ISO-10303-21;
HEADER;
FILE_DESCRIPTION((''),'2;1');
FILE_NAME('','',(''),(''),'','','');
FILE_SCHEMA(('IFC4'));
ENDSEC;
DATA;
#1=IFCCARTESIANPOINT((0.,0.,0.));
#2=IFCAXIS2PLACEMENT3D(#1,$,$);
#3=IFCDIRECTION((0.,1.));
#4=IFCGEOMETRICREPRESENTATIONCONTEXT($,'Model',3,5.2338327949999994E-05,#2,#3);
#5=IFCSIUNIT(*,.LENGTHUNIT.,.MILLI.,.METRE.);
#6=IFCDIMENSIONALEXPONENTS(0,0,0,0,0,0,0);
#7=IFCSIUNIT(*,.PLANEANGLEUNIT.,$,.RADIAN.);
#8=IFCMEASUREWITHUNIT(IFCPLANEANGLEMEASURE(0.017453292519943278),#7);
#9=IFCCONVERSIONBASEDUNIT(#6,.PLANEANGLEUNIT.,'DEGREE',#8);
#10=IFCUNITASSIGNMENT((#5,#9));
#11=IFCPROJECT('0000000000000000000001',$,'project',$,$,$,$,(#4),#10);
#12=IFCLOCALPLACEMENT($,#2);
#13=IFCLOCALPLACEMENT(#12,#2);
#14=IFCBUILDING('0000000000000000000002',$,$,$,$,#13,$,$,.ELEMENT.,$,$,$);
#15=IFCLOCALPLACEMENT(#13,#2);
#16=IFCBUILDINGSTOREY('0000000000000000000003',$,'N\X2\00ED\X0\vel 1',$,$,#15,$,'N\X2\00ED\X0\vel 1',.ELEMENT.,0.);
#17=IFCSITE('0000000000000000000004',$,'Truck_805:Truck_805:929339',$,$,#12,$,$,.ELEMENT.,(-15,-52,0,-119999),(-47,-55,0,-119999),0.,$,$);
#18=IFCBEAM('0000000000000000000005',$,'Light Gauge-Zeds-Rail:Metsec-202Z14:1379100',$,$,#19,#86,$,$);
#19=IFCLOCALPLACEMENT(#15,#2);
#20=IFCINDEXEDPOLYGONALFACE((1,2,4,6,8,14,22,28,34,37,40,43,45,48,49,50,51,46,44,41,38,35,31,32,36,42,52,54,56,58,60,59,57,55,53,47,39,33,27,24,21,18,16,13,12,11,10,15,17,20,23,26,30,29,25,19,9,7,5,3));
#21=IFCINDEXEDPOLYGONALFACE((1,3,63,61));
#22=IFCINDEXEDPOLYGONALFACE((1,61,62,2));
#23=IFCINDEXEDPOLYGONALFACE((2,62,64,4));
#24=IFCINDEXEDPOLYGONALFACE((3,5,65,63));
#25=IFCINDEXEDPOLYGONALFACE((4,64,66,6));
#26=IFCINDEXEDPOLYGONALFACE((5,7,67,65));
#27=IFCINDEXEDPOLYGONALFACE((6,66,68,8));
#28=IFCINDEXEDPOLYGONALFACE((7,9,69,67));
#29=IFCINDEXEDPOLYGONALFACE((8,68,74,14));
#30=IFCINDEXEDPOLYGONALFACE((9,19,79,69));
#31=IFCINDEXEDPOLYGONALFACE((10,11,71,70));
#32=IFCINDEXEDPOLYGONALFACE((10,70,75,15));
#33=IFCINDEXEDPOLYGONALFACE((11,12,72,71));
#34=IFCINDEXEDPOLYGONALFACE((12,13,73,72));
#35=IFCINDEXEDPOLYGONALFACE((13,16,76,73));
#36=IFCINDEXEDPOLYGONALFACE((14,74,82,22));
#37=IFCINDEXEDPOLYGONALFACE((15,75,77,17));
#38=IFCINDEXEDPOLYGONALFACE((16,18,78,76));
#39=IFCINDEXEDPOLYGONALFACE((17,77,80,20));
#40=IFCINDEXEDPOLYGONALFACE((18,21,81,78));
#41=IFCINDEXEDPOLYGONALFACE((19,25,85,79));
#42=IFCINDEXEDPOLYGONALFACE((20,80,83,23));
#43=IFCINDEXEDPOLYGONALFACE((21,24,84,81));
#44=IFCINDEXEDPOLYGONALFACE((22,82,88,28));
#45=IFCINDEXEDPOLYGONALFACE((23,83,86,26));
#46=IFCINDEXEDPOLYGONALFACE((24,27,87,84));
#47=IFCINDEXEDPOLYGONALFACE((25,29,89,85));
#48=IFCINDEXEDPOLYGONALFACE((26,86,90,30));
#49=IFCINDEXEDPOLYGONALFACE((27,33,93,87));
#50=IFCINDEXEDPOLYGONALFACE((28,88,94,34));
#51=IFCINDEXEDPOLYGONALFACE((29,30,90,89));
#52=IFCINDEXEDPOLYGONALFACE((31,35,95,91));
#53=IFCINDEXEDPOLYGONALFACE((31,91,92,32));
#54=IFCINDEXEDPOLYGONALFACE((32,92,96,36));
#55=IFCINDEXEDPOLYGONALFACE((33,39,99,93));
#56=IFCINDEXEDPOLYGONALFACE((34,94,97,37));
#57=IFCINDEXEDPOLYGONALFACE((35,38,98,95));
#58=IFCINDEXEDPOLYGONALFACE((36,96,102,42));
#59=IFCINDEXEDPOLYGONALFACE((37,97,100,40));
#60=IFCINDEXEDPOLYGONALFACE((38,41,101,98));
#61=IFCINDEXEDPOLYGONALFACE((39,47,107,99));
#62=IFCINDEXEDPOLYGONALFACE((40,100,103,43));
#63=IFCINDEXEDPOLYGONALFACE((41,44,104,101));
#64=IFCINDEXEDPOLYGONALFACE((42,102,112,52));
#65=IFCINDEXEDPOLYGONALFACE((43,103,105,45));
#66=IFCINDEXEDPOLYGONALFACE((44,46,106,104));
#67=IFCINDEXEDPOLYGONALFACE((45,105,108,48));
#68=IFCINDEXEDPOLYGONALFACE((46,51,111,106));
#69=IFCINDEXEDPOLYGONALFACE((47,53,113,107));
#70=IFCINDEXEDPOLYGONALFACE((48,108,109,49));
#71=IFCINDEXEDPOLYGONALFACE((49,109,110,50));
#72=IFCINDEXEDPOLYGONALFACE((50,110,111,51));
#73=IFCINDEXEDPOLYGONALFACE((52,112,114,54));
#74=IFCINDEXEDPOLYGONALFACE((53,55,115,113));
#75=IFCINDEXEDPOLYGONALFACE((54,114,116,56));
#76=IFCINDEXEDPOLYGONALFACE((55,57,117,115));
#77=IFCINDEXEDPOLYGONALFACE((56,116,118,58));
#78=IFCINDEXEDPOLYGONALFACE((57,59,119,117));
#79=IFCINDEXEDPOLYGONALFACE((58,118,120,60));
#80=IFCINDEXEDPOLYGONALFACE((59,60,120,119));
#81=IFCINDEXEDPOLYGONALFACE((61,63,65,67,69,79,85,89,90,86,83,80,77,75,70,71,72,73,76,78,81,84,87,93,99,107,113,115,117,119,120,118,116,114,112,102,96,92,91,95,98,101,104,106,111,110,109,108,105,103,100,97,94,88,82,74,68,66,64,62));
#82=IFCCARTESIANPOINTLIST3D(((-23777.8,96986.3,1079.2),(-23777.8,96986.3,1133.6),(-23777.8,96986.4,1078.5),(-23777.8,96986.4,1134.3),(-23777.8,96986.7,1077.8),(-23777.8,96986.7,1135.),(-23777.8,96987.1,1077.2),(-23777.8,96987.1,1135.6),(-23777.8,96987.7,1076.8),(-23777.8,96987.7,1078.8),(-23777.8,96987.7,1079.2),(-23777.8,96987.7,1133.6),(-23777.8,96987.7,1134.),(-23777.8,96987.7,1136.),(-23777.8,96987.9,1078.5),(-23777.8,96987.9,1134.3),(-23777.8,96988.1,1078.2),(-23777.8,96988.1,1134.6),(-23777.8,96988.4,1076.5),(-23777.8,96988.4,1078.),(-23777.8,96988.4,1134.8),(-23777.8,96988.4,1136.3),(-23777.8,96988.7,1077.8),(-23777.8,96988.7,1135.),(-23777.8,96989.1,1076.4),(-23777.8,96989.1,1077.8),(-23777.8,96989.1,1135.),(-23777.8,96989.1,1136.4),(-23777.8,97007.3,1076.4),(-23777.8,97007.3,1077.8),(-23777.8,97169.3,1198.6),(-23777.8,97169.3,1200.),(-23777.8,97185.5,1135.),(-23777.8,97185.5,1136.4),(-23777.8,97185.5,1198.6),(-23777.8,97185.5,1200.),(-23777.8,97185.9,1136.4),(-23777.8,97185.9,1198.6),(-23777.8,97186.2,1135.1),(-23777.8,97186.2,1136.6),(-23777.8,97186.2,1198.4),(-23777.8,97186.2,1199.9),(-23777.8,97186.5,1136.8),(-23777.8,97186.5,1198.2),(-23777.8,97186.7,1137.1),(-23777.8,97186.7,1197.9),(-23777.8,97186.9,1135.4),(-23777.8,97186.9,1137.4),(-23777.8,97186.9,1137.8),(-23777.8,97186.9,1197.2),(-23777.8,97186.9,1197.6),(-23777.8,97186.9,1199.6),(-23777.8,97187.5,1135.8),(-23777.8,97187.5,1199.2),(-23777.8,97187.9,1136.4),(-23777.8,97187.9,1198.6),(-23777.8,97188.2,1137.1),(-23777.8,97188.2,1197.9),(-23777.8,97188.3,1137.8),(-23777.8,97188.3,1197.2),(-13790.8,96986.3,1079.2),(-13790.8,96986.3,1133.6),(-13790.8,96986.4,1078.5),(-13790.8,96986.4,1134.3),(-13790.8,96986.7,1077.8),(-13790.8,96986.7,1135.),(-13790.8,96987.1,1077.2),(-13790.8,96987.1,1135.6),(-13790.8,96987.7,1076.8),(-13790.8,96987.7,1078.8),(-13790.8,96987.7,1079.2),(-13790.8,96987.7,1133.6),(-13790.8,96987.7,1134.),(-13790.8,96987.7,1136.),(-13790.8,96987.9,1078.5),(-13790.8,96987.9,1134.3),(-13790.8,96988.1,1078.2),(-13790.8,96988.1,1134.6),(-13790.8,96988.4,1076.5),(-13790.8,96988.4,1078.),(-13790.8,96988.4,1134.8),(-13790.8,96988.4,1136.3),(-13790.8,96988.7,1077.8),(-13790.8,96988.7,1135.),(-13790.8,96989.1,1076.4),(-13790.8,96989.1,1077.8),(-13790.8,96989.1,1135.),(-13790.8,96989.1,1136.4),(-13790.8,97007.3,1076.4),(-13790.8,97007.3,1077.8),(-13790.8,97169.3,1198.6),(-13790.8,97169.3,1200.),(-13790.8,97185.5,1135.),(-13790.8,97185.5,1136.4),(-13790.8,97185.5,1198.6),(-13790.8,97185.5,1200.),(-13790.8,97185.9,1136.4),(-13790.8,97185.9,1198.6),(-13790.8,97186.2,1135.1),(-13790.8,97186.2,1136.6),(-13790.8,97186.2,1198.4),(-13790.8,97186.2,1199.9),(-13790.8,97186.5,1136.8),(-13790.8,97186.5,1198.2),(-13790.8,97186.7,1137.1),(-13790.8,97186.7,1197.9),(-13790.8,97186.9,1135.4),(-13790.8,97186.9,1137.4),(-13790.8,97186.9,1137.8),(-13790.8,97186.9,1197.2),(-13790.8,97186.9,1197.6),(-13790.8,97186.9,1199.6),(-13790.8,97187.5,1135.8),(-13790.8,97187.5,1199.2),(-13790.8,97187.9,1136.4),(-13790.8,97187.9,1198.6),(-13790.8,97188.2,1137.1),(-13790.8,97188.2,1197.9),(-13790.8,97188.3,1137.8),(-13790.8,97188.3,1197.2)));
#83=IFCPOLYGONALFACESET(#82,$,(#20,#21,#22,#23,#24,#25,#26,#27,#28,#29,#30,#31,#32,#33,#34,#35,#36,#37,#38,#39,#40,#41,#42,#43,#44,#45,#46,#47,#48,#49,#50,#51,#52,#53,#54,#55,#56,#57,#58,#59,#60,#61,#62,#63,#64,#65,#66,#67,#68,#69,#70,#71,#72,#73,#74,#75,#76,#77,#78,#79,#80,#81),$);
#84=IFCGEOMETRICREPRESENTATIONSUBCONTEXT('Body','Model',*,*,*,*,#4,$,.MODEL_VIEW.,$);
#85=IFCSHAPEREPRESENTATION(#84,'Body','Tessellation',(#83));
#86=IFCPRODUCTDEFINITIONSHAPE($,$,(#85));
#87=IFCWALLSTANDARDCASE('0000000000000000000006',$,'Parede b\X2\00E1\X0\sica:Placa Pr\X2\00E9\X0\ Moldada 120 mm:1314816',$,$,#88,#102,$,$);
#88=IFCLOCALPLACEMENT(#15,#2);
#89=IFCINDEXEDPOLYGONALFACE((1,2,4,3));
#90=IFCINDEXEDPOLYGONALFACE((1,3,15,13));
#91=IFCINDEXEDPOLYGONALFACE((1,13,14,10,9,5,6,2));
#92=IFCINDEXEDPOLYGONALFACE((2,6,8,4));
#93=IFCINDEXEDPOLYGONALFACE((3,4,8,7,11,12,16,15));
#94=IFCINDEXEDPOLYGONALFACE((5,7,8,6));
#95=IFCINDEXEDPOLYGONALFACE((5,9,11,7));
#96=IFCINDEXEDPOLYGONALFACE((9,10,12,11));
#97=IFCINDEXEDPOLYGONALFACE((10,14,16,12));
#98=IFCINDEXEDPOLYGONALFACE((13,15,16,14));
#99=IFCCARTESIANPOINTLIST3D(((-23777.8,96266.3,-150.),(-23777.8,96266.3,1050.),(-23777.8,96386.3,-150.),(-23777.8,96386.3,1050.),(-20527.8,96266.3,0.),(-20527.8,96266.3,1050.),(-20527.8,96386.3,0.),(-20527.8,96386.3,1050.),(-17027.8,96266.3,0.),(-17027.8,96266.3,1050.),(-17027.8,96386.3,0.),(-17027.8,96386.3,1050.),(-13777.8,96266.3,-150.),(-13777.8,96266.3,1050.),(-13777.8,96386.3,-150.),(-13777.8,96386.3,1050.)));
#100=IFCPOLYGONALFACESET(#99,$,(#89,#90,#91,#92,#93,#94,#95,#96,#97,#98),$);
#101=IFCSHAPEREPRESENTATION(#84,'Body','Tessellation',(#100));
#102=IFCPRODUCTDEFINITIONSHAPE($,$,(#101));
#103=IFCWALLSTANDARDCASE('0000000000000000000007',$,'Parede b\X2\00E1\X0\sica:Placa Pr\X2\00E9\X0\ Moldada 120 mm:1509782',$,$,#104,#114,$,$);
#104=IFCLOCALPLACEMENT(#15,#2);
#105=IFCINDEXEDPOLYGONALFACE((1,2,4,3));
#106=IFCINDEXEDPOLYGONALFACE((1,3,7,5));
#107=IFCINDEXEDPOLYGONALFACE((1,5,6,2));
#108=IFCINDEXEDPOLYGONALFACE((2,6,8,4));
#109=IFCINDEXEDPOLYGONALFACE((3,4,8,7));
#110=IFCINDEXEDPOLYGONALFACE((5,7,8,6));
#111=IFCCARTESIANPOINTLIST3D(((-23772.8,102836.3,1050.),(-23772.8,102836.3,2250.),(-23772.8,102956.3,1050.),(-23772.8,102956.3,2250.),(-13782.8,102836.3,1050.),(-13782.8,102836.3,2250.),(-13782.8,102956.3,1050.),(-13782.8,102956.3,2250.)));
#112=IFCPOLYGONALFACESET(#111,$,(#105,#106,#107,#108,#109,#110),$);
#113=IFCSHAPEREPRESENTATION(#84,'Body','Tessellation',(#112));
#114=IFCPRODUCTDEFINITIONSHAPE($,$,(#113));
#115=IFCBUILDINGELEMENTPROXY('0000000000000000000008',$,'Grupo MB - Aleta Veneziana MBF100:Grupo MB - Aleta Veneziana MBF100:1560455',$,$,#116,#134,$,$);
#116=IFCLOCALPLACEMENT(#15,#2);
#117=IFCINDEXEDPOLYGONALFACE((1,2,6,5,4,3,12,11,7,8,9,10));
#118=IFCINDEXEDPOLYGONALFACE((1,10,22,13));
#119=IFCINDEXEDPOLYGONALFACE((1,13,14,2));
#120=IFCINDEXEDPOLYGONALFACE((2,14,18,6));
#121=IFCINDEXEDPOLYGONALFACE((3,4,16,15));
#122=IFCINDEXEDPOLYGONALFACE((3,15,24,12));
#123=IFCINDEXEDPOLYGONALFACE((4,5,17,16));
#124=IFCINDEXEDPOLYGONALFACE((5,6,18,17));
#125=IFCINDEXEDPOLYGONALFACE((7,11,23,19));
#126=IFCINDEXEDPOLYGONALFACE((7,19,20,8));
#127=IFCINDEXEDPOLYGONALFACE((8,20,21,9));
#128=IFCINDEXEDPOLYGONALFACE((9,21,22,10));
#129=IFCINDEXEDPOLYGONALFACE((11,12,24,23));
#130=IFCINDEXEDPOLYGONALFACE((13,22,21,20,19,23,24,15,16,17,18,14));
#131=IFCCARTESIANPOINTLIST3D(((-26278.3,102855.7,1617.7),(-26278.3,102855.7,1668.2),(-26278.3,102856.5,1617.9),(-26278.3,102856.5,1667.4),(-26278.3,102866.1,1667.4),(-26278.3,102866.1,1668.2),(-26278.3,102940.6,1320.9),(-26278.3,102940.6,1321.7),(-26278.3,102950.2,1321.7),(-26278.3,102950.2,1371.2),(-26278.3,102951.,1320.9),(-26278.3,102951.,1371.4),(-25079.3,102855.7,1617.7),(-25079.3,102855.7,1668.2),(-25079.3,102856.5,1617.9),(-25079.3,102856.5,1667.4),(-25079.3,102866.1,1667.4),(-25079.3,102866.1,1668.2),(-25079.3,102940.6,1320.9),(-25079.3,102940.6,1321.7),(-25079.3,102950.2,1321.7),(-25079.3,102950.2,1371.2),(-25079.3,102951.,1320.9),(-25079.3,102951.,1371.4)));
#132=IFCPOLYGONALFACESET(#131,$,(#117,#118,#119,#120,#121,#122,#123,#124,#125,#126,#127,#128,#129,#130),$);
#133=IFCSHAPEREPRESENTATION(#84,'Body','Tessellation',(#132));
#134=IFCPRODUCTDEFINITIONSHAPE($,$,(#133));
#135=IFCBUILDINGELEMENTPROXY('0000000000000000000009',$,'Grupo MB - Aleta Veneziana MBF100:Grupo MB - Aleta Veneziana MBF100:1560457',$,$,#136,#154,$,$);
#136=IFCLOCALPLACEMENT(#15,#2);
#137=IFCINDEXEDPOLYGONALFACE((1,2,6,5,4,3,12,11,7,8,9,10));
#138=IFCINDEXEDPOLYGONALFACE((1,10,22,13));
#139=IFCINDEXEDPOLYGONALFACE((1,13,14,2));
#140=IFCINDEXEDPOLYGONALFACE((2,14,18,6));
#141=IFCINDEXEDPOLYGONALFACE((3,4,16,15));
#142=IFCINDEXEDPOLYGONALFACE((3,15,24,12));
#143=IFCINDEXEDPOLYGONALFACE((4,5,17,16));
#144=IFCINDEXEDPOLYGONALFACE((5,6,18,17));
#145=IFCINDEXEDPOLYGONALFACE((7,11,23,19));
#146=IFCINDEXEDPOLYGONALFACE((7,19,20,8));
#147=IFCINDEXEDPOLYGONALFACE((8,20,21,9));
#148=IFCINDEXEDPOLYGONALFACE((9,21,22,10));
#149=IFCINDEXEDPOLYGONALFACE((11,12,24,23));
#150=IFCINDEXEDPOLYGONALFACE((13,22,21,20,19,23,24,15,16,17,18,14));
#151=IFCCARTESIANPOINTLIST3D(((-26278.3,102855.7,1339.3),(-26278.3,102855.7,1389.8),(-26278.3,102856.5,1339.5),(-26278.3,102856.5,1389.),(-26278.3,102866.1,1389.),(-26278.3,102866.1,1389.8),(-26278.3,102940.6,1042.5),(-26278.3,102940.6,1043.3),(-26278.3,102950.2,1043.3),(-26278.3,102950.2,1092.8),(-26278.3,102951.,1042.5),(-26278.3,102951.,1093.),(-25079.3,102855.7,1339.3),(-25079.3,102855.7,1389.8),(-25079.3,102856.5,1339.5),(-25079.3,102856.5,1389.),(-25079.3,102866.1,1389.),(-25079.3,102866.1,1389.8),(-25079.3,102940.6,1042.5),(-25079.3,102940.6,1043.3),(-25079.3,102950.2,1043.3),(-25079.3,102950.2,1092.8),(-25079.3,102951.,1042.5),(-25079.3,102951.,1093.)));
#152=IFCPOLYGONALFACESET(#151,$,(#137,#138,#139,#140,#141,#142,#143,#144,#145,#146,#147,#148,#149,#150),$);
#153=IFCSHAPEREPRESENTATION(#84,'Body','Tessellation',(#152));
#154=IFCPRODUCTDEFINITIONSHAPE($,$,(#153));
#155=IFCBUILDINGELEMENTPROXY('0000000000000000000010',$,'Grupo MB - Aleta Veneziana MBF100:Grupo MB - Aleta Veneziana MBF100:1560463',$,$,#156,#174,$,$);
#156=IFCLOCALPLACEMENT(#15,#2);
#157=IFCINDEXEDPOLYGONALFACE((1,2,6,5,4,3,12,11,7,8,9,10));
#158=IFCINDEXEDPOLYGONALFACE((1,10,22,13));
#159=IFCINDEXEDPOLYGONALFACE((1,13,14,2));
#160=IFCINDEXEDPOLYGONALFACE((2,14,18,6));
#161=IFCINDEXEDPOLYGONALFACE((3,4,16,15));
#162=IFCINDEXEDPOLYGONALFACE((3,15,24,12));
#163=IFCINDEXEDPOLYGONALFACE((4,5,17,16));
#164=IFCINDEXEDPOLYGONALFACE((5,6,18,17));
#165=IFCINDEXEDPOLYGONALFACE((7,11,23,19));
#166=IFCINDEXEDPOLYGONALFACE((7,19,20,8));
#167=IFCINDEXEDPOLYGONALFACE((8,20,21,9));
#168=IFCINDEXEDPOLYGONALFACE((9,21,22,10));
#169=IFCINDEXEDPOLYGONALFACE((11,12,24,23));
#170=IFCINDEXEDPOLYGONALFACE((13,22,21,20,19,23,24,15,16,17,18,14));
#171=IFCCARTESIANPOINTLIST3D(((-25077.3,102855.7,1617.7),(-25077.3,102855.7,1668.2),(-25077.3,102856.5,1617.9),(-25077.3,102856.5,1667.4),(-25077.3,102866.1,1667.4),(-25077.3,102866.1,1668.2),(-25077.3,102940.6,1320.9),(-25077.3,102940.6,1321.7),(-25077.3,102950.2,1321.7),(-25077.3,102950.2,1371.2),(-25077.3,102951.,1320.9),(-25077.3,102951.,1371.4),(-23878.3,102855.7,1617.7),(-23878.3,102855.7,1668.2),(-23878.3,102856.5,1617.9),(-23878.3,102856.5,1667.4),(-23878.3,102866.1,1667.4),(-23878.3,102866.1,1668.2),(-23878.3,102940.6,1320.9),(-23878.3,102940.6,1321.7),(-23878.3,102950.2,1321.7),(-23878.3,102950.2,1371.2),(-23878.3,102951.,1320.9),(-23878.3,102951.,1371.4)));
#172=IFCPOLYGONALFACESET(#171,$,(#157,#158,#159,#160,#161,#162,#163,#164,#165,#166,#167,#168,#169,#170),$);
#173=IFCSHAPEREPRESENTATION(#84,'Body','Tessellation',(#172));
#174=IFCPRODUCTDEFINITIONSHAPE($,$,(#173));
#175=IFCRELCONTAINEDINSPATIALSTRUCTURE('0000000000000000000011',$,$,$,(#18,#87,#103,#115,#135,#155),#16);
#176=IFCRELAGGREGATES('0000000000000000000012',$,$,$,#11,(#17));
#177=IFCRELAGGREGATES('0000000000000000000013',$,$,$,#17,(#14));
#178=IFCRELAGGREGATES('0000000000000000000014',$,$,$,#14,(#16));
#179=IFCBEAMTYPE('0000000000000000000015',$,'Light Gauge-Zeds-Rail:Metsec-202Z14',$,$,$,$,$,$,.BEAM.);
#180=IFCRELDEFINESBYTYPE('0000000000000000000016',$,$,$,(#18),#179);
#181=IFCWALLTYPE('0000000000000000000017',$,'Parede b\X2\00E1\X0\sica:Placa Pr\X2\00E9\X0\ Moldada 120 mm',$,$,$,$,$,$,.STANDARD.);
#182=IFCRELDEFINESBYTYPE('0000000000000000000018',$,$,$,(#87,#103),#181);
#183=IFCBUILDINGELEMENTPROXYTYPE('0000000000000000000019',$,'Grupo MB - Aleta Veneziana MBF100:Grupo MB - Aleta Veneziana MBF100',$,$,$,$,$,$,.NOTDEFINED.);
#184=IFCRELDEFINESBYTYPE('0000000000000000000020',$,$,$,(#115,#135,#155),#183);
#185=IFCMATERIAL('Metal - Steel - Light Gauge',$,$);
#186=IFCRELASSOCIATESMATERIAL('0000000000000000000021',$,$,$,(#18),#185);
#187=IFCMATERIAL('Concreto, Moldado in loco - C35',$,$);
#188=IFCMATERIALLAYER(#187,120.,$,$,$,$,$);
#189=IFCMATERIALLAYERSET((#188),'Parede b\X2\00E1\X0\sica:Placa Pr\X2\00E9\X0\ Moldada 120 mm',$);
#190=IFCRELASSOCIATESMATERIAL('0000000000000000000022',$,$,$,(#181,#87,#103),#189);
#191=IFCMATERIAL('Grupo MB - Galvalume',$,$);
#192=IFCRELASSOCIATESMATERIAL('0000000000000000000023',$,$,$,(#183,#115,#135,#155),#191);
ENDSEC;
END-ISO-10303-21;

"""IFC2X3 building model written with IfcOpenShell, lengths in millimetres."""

from ifc_helpers import new_model, entity, si_unit, converted_unit, direction, frame, frame_2d, origin, place, context, subcontext, project, spatial, polyline, circle_curve, parameter, trimmed, segment, composite_curve, rectangle, outline, extrude, source, transform, mapped, material, layer, layer_set, layer_usage, type_object, type_shapes, element, save


model = new_model("IFC2X3")

# Units and contexts
model_context = context("Model", 3, precision=5.2338327949999994e-05, world=origin(), true_north=direction((0.0, 1.0)))
body_context = subcontext(model_context, "Body", "Model", "MODEL_VIEW")
ifc_project = project(units=[si_unit("LENGTHUNIT", "METRE", prefix="MILLI"), converted_unit("PLANEANGLEUNIT", "DEGREE", entity("IfcPlaneAngleMeasure", 0.017453292519943278), si_unit("PLANEANGLEUNIT", "RADIAN"), dimensions=[0, 0, 0, 0, 0, 0, 0])], contexts=[model_context])

# Site, building, storey
site_placement = place(None, origin())
site = spatial("IfcSite", under=ifc_project, at=site_placement, Name="Truck_805:Truck_805:929339", CompositionType="ELEMENT", RefLatitude=(-15, -52, 0, -119999), RefLongitude=(-47, -55, 0, -119999), RefElevation=0.0)
building_placement = place(site_placement, origin())
building = spatial("IfcBuilding", under=site, at=building_placement, CompositionType="ELEMENT")
storey_placement = place(building_placement, origin())
storey = spatial("IfcBuildingStorey", under=building, at=storey_placement, Name="Nível 1", LongName="Nível 1", CompositionType="ELEMENT", Elevation=0.0)

# Beam
ifc_material_1 = material(Name="Metal - Steel - Light Gauge")
beam_type = type_object("IfcBeamType", Name="Light Gauge-Zeds-Rail:Metsec-202Z14", PredefinedType="BEAM")
beam_placement = place(storey_placement, frame((-23777.8, 97088.2, 1200.0)))
element("IfcBeam", 1, at=beam_placement, inside=storey, type_object=beam_type, material=ifc_material_1, Name="Light Gauge-Zeds-Rail:Metsec-202Z14:1379100", context=body_context, shape_type="SweptSolid", body=[
    extrude(outline(composite_curve([segment(polyline([(3.6, -101.2), (58.0, -101.2)]), True, "CONTINUOUS"), segment(trimmed(circle_curve(frame_2d((58.0, -98.4), x_axis=(0.0, -1.0)), 2.8), [parameter(0.0)], [parameter(90.0)], True, "PARAMETER"), True, "CONTINUOUS"), segment(polyline([(60.8, -98.4), (60.8, -80.2)]), True, "CONTINUOUS"), segment(polyline([(60.8, -80.2), (59.4, -80.2)]), True, "CONTINUOUS"), segment(polyline([(59.4, -80.2), (59.4, -98.4)]), True, "CONTINUOUS"), segment(trimmed(circle_curve(frame_2d((58.0, -98.4), x_axis=(1.0, 0.0)), 1.4), [parameter(270.0)], [parameter(0.0)], True, "PARAMETER"), False, "CONTINUOUS"), segment(polyline([(58.0, -99.8), (3.6, -99.8)]), True, "CONTINUOUS"), segment(trimmed(circle_curve(frame_2d((3.6, -98.4), x_axis=(0.0, -1.0)), 1.4), [parameter(270.0)], [parameter(0.0)], True, "PARAMETER"), False, "CONTINUOUS"), segment(polyline([(2.2, -98.4), (2.2, 98.0)]), True, "CONTINUOUS"), segment(trimmed(circle_curve(frame_2d((-0.6, 98.0), x_axis=(1.0, 0.0)), 2.8), [parameter(0.0)], [parameter(90.0)], True, "PARAMETER"), True, "CONTINUOUS"), segment(polyline([(-0.6, 100.8), (-60.0, 100.8)]), True, "CONTINUOUS"), segment(trimmed(circle_curve(frame_2d((-60.0, 98.0), x_axis=(0.0, 1.0)), 2.8), [parameter(0.0)], [parameter(90.0)], True, "PARAMETER"), True, "CONTINUOUS"), segment(polyline([(-62.8, 98.0), (-62.8, 81.8)]), True, "CONTINUOUS"), segment(polyline([(-62.8, 81.8), (-61.4, 81.8)]), True, "CONTINUOUS"), segment(polyline([(-61.4, 81.8), (-61.4, 98.0)]), True, "CONTINUOUS"), segment(trimmed(circle_curve(frame_2d((-60.0, 98.0), x_axis=(-1.0, 0.0)), 1.4), [parameter(270.0)], [parameter(0.0)], True, "PARAMETER"), False, "CONTINUOUS"), segment(polyline([(-60.0, 99.4), (-0.6, 99.4)]), True, "CONTINUOUS"), segment(trimmed(circle_curve(frame_2d((-0.6, 98.0), x_axis=(0.0, 1.0)), 1.4), [parameter(270.0)], [parameter(0.0)], True, "PARAMETER"), False, "CONTINUOUS"), segment(polyline([(0.8, 98.0), (0.8, -98.4)]), True, "CONTINUOUS"), segment(trimmed(circle_curve(frame_2d((3.6, -98.4), x_axis=(-1.0, 0.0)), 2.8), [parameter(0.0)], [parameter(90.0)], True, "PARAMETER"), True, "CONTINUOUS")], self_intersect=False)), frame((0.0, -0.7, -62.8), z_axis=(1.0, 0.0, 0.0), x_axis=(0.0, 0.0, -1.0)), (0.0, 0.0, 1.0), 9987.0),
])

# Wall, opening
ifc_material_2 = material(Name="Concreto, Moldado in loco - C35")
ifc_layer = layer(ifc_material_2, 120.0)
ifc_layer_set = layer_set([ifc_layer], Name="Parede básica:Placa Pré Moldada 120 mm")
ifc_layer_usage_1 = layer_usage(ifc_layer_set, "AXIS2", "NEGATIVE", 60.0)
wall_type = type_object("IfcWallType", Name="Parede básica:Placa Pré Moldada 120 mm", PredefinedType="STANDARD", material=ifc_layer_set)
wall_1_placement = place(storey_placement, frame((-23777.8, 96326.3, -150.0)))
wall_1 = element("IfcWallStandardCase", 2, at=wall_1_placement, inside=storey, type_object=wall_type, material=ifc_layer_usage_1, Name="Parede básica:Placa Pré Moldada 120 mm:1314816", context=body_context, shape_type="SweptSolid", body=[
    extrude(rectangle(XDim=10000.0, YDim=120.0, at=frame_2d((5000.0, 0.0), x_axis=(-1.0, 0.0))), origin(), (0.0, 0.0, 1.0), 1200.0),
])
opening_placement = place(wall_1_placement, frame((3250.0, -60.0, 150.0)))
element("IfcOpeningElement", 3, at=opening_placement, cuts=wall_1, ObjectType="Opening", context=body_context, shape_type="SweptSolid", body=[
    extrude(rectangle(XDim=4000.0, YDim=3500.0, at=frame_2d((2000.0, 1750.0), x_axis=(1.0, 0.0))), frame((0.0, 0.0, 0.0), z_axis=(0.0, 1.0, 0.0), x_axis=(0.0, 0.0, 1.0)), (0.0, 0.0, 1.0), 120.0),
])

# Wall
ifc_layer_usage_2 = layer_usage(ifc_layer_set, "AXIS2", "POSITIVE", -60.0)
wall_2_placement = place(storey_placement, frame((-23772.8, 102896.3, 1050.0)))
element("IfcWallStandardCase", 4, at=wall_2_placement, inside=storey, type_object=wall_type, material=ifc_layer_usage_2, Name="Parede básica:Placa Pré Moldada 120 mm:1509782", context=body_context, shape_type="SweptSolid", body=[
    extrude(rectangle(XDim=9990.0, YDim=120.0, at=frame_2d((4995.0, 0.0), x_axis=(-1.0, 0.0))), origin(), (0.0, 0.0, 1.0), 1200.0),
])

# Building element proxies
ifc_material_3 = material(Name="Grupo MB - Galvalume")
building_element_proxy_type_1 = type_object("IfcBuildingElementProxyType", Name="Grupo MB - Aleta Veneziana MBF100:Grupo MB - Aleta Veneziana MBF100", PredefinedType="NOTDEFINED", material=ifc_material_3)
shared_shape_1 = source(origin(), body_context, "Body", "SweptSolid", [
    extrude(outline(polyline([(123.3, -46.8), (-123.2, 47.6), (-173.7, 47.6), (-173.7, 37.2), (-172.9, 37.2), (-172.9, 46.8), (-123.3, 46.8), (123.2, -47.6), (173.7, -47.6), (173.7, -37.2), (172.9, -37.2), (172.9, -46.8), (123.3, -46.8)])), frame((0.0, 47.6, 173.7), z_axis=(-1.0, 0.0, 0.0), x_axis=(0.0, 0.0, -1.0)), (0.0, 0.0, -1.0), 1199.0),
])
type_shapes(building_element_proxy_type_1, [shared_shape_1])
for number, where, name in (
    (5, (-26278.3, 102855.7, 1320.9), "Grupo MB - Aleta Veneziana MBF100:Grupo MB - Aleta Veneziana MBF100:1560455"),
    (6, (-26278.3, 102855.7, 1042.5), "Grupo MB - Aleta Veneziana MBF100:Grupo MB - Aleta Veneziana MBF100:1560457"),
    (7, (-25077.3, 102855.7, 1320.9), "Grupo MB - Aleta Veneziana MBF100:Grupo MB - Aleta Veneziana MBF100:1560463"),
):
    element("IfcBuildingElementProxy", number, at=place(storey_placement, frame(where)), inside=storey, type_object=building_element_proxy_type_1, material=ifc_material_3, Name=name, context=body_context, shape_type="MappedRepresentation", body=[
        mapped(shared_shape_1, transform((0.0, 0.0, 0.0), scale=1.0)),
    ])

save(model, "model.ifc")
